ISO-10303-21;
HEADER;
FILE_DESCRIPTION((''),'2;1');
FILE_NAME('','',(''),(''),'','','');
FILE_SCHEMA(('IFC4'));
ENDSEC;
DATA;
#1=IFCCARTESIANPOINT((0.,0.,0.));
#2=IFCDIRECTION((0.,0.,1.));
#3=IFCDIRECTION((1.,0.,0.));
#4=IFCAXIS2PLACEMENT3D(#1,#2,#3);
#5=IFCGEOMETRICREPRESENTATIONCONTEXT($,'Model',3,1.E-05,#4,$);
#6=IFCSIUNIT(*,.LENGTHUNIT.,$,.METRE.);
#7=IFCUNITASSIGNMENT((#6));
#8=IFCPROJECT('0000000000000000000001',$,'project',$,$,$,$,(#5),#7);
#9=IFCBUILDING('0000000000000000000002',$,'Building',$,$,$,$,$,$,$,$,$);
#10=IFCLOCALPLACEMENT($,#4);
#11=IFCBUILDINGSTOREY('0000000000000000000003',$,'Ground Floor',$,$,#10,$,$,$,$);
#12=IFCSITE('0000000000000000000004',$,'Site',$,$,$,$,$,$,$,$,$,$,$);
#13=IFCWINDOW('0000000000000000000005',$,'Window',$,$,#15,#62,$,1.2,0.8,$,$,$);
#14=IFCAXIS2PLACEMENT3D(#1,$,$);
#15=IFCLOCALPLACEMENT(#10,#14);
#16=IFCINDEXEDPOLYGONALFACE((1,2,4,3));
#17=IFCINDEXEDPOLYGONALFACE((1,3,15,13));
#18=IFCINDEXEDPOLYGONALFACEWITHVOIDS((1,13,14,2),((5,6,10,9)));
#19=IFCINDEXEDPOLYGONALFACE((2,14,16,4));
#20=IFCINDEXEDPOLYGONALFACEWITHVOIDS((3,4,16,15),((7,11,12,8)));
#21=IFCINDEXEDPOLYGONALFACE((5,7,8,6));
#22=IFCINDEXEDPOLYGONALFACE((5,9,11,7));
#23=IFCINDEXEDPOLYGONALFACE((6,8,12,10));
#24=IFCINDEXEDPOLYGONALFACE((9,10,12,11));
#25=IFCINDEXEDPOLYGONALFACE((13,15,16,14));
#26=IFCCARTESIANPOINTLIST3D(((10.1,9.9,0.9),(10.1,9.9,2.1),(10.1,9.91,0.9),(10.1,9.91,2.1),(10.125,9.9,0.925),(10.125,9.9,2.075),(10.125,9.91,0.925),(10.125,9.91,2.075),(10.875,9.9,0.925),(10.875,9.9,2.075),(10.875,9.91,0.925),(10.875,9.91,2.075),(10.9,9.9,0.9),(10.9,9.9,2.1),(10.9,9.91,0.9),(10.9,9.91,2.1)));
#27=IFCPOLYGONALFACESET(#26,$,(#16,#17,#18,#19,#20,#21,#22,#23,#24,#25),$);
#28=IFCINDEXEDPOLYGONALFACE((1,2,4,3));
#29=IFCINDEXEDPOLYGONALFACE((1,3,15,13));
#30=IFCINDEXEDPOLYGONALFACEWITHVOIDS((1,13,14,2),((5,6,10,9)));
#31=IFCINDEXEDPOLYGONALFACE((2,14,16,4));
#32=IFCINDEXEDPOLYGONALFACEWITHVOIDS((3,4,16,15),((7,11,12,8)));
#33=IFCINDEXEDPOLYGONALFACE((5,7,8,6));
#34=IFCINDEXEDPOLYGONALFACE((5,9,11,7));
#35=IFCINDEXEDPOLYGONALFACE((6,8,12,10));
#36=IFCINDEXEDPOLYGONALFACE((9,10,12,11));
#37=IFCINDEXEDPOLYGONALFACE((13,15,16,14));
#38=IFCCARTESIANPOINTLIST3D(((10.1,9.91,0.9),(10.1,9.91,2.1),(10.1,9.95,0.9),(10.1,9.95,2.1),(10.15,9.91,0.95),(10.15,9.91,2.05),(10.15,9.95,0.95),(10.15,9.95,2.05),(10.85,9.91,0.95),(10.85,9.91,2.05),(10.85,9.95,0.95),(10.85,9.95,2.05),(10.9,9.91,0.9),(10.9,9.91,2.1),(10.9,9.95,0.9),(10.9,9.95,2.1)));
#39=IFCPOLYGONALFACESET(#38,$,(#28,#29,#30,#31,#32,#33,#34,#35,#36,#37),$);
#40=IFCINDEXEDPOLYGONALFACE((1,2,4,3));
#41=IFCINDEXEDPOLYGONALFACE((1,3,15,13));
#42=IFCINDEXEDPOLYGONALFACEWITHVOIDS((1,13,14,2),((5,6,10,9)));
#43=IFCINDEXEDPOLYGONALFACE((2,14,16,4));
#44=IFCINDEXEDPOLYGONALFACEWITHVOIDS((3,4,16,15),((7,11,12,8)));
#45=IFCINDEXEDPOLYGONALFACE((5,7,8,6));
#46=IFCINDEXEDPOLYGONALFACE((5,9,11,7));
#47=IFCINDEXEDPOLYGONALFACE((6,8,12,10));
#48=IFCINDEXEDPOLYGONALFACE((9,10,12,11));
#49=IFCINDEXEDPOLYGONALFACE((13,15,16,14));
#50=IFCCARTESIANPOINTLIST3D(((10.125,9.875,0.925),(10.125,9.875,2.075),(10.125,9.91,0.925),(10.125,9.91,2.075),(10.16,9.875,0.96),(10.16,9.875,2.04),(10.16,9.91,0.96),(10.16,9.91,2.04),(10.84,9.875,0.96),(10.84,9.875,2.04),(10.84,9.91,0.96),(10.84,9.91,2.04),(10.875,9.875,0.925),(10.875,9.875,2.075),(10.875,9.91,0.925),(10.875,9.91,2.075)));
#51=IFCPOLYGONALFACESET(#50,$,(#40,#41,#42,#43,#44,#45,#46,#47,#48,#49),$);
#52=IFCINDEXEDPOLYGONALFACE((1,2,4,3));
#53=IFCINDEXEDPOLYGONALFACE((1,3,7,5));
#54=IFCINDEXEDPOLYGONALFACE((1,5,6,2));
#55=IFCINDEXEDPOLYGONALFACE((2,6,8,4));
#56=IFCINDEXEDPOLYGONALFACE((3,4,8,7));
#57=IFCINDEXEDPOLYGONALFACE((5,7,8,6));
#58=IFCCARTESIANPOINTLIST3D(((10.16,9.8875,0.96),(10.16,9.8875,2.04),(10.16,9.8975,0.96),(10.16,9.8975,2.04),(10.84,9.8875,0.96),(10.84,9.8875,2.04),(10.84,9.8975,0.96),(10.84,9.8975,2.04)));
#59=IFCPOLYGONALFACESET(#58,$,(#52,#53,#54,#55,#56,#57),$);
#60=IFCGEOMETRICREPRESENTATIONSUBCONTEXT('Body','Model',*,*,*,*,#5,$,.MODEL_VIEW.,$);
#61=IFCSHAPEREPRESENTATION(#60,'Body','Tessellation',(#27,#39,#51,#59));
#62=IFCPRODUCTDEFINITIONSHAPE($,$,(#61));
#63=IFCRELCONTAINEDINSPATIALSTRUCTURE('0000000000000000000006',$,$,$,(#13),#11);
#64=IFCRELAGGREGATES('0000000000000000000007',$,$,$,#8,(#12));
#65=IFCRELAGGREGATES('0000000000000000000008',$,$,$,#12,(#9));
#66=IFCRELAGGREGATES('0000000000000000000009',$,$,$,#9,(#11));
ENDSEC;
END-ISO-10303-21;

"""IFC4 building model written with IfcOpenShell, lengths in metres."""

from ifc_helpers import new_model, si_unit, frame, origin_with_axes, place, context, subcontext, project, spatial, line, indexed_curve, outline, extrude, element, save


model = new_model("IFC4")

# Units and contexts
model_context = context("Model", 3, precision=1e-05, world=origin_with_axes())
body_context = subcontext(model_context, "Body", "Model", "MODEL_VIEW")
ifc_project = project(units=[si_unit("LENGTHUNIT", "METRE")], contexts=[model_context])

# Site, building, storey
site = spatial("IfcSite", under=ifc_project, Name="Site")
building = spatial("IfcBuilding", under=site, Name="Building")
storey_placement = place(None, origin_with_axes())
storey = spatial("IfcBuildingStorey", under=building, at=storey_placement, Name="Ground Floor")

# Window
for number, where, z_axis, x_axis, name in (
    (1, (10.9, 10.0, 0.9), (0.0, 0.0, 1.0), (-1.0, 0.0, 0.0), "Window"),
):
    element("IfcWindow", number, at=place(storey_placement, frame(where, z_axis=z_axis, x_axis=x_axis)), inside=storey, Name=name, OverallHeight=1.2, OverallWidth=0.8, context=body_context, shape_type="SweptSolid", body=[
        extrude(outline(indexed_curve([(0.0, 0.0), (0.8, 0.0), (0.8, 1.2), (0.0, 1.2)], segments=[line(1, 2, 3, 4, 1)]), holes=[indexed_curve([(0.025, 0.025), (0.775, 0.025), (0.775, 1.175), (0.025, 1.175)], segments=[line(1, 2, 3, 4, 1)])]), frame((0.0, 0.09, 0.0), z_axis=(0.0, -1.0, 0.0), x_axis=(1.0, 0.0, 0.0)), (0.0, 0.0, -1.0), 0.01),
        extrude(outline(indexed_curve([(0.0, 0.0), (0.8, 0.0), (0.8, 1.2), (0.0, 1.2)], segments=[line(1, 2, 3, 4, 1)]), holes=[indexed_curve([(0.05, 0.05), (0.75, 0.05), (0.75, 1.15), (0.05, 1.15)], segments=[line(1, 2, 3, 4, 1)])]), frame((0.0, 0.05, 0.0), z_axis=(0.0, -1.0, 0.0), x_axis=(1.0, 0.0, 0.0)), (0.0, 0.0, -1.0), 0.04),
        extrude(outline(indexed_curve([(0.0, 0.0), (0.75, 0.0), (0.75, 1.15), (0.0, 1.15)], segments=[line(1, 2, 3, 4, 1)]), holes=[indexed_curve([(0.035, 0.035), (0.715, 0.035), (0.715, 1.115), (0.035, 1.115)], segments=[line(1, 2, 3, 4, 1)])]), frame((0.025, 0.09, 0.025), z_axis=(0.0, -1.0, 0.0), x_axis=(1.0, 0.0, 0.0)), (0.0, 0.0, -1.0), 0.035),
        extrude(outline(indexed_curve([(0.035, 0.035), (0.715, 0.035), (0.715, 1.115), (0.035, 1.115)], segments=[line(1, 2, 3, 4, 1)])), frame((0.025, 0.1025, 0.025), z_axis=(0.0, -1.0, 0.0), x_axis=(1.0, 0.0, 0.0)), (0.0, 0.0, -1.0), 0.01),
    ])

save(model, "model.ifc")
